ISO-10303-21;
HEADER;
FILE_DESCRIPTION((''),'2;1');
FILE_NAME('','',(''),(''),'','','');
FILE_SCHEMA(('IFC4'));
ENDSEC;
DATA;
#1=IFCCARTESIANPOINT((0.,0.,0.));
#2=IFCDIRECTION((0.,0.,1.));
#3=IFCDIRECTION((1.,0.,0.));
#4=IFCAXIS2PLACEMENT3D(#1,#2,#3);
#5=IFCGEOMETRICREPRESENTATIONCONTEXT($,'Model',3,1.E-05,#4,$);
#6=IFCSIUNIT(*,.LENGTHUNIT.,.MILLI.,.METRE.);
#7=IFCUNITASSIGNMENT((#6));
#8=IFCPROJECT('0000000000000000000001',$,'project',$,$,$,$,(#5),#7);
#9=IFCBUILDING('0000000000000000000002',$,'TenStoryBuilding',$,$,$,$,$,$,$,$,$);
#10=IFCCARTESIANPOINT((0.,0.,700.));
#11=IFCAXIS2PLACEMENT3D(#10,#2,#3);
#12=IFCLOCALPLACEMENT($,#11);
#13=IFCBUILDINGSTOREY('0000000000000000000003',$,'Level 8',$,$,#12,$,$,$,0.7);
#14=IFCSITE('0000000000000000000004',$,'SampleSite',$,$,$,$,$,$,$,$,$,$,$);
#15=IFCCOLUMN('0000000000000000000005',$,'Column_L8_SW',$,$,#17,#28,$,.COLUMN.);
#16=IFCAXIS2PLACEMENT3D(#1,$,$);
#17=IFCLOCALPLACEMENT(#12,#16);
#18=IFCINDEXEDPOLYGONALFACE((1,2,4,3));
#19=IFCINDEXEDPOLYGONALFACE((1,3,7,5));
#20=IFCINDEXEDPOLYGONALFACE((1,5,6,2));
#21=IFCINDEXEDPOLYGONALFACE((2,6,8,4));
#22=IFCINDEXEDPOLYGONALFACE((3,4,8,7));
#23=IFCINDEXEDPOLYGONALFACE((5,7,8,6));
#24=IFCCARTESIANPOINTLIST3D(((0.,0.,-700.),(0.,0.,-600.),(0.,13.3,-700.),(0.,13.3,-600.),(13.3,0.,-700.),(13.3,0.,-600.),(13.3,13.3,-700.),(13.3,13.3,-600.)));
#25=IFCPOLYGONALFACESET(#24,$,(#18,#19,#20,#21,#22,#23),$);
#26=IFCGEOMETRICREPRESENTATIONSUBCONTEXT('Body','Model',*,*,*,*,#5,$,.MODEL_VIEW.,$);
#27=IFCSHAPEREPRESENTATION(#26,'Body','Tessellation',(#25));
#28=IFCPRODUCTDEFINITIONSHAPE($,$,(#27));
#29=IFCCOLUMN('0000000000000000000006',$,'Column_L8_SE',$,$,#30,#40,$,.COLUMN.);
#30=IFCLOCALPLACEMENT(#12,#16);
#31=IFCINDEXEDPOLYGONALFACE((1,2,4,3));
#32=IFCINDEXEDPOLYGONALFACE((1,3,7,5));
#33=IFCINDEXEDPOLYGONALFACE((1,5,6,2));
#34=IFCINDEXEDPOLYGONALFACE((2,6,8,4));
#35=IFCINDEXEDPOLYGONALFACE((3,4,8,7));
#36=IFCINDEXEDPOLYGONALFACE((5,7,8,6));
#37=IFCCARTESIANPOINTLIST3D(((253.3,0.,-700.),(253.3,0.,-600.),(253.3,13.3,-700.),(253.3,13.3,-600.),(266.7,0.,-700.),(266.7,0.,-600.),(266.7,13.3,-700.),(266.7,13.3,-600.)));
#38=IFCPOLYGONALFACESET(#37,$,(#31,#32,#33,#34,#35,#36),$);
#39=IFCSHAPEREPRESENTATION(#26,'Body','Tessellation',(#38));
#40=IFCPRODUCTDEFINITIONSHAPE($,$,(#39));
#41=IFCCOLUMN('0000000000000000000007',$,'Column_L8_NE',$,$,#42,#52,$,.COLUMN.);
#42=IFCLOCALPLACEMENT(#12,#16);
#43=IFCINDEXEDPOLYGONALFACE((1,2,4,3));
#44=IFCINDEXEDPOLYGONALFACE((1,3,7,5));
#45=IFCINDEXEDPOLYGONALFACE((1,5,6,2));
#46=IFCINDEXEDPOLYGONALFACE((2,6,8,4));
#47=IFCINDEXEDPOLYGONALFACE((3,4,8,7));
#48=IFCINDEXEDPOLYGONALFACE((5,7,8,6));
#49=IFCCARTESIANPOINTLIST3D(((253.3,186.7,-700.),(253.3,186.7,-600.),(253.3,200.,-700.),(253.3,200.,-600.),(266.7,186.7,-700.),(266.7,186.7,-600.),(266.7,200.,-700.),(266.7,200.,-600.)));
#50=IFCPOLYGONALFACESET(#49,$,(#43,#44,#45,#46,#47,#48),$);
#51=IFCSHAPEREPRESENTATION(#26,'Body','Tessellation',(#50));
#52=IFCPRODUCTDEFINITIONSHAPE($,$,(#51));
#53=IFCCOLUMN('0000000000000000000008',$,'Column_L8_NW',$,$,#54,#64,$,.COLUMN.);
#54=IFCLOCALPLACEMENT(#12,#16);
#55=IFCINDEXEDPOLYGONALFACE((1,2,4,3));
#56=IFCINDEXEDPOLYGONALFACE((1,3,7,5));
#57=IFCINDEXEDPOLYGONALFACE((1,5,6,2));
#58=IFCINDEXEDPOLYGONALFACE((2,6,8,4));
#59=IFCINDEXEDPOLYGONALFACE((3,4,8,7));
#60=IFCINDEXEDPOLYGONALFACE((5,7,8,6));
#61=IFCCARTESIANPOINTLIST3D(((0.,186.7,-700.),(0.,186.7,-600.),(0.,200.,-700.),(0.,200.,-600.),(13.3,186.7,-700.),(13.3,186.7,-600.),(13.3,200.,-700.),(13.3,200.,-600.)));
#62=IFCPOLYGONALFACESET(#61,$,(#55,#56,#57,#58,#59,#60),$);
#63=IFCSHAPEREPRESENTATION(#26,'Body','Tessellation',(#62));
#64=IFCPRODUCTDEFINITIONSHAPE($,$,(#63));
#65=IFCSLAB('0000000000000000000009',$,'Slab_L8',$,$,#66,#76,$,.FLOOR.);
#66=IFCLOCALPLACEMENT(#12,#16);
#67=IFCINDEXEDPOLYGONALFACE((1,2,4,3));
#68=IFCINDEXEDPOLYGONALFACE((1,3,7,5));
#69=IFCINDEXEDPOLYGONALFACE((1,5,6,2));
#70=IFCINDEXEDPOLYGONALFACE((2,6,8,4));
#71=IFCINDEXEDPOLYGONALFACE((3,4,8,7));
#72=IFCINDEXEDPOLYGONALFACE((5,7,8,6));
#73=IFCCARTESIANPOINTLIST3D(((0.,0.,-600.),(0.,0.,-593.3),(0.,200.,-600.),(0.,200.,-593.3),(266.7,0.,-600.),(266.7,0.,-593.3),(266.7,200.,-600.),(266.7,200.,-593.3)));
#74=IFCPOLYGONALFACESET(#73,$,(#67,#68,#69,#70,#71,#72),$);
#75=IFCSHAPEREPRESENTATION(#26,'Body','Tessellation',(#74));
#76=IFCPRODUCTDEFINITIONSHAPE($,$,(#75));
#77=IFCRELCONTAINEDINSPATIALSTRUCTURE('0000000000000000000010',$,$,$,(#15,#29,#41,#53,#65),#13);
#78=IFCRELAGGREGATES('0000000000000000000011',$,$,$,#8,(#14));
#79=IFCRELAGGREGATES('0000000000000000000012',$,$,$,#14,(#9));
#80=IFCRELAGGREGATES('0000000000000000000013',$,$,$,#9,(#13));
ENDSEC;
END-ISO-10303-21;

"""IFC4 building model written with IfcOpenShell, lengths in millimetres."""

from ifc_helpers import new_model, si_unit, frame, origin_with_axes, origin_2d, place, context, subcontext, project, spatial, indexed_curve, rectangle, outline, extrude, element, save


model = new_model("IFC4")

# Units and contexts
model_context = context("Model", 3, precision=1e-05, world=origin_with_axes())
body_context = subcontext(model_context, "Body", "Model", "MODEL_VIEW")
ifc_project = project(units=[si_unit("LENGTHUNIT", "METRE", prefix="MILLI")], contexts=[model_context])

# Site, building, storey
site = spatial("IfcSite", under=ifc_project, Name="SampleSite")
building = spatial("IfcBuilding", under=site, Name="TenStoryBuilding")
storey_placement = place(None, frame((0.0, 0.0, 700.0), z_axis=(0.0, 0.0, 1.0), x_axis=(1.0, 0.0, 0.0)))
storey = spatial("IfcBuildingStorey", under=building, at=storey_placement, Name="Level 8", Elevation=0.7)

# Columns
for number, where, z_axis, x_axis, name in (
    (1, (6.7, 6.7, -700.0), (0.0, 0.0, 1.0), (1.0, 0.0, 0.0), "Column_L8_SW"),
    (2, (260.0, 6.7, -700.0), (0.0, 0.0, 1.0), (1.0, 0.0, 0.0), "Column_L8_SE"),
    (3, (260.0, 193.3, -700.0), (0.0, 0.0, 1.0), (1.0, 0.0, 0.0), "Column_L8_NE"),
    (4, (6.7, 193.3, -700.0), (0.0, 0.0, 1.0), (1.0, 0.0, 0.0), "Column_L8_NW"),
):
    element("IfcColumn", number, at=place(storey_placement, frame(where, z_axis=z_axis, x_axis=x_axis)), inside=storey, Name=name, PredefinedType="COLUMN", context=body_context, shape_type="SweptSolid", body=[
        extrude(rectangle(XDim=13.3, YDim=13.3, at=origin_2d()), origin_with_axes(), (0.0, 0.0, 1.0), 100.0),
    ])

# Slab
slab_placement = place(storey_placement, frame((0.0, 0.0, -600.0), z_axis=(0.0, 0.0, 1.0), x_axis=(1.0, 0.0, 0.0)))
element("IfcSlab", 5, at=slab_placement, inside=storey, Name="Slab_L8", PredefinedType="FLOOR", context=body_context, shape_type="SweptSolid", body=[
    extrude(outline(indexed_curve([(0.0, 0.0), (266.7, 0.0), (266.7, 200.0), (0.0, 200.0), (0.0, 0.0)])), None, (0.0, 0.0, 1.0), 6.7),
])

save(model, "model.ifc")
